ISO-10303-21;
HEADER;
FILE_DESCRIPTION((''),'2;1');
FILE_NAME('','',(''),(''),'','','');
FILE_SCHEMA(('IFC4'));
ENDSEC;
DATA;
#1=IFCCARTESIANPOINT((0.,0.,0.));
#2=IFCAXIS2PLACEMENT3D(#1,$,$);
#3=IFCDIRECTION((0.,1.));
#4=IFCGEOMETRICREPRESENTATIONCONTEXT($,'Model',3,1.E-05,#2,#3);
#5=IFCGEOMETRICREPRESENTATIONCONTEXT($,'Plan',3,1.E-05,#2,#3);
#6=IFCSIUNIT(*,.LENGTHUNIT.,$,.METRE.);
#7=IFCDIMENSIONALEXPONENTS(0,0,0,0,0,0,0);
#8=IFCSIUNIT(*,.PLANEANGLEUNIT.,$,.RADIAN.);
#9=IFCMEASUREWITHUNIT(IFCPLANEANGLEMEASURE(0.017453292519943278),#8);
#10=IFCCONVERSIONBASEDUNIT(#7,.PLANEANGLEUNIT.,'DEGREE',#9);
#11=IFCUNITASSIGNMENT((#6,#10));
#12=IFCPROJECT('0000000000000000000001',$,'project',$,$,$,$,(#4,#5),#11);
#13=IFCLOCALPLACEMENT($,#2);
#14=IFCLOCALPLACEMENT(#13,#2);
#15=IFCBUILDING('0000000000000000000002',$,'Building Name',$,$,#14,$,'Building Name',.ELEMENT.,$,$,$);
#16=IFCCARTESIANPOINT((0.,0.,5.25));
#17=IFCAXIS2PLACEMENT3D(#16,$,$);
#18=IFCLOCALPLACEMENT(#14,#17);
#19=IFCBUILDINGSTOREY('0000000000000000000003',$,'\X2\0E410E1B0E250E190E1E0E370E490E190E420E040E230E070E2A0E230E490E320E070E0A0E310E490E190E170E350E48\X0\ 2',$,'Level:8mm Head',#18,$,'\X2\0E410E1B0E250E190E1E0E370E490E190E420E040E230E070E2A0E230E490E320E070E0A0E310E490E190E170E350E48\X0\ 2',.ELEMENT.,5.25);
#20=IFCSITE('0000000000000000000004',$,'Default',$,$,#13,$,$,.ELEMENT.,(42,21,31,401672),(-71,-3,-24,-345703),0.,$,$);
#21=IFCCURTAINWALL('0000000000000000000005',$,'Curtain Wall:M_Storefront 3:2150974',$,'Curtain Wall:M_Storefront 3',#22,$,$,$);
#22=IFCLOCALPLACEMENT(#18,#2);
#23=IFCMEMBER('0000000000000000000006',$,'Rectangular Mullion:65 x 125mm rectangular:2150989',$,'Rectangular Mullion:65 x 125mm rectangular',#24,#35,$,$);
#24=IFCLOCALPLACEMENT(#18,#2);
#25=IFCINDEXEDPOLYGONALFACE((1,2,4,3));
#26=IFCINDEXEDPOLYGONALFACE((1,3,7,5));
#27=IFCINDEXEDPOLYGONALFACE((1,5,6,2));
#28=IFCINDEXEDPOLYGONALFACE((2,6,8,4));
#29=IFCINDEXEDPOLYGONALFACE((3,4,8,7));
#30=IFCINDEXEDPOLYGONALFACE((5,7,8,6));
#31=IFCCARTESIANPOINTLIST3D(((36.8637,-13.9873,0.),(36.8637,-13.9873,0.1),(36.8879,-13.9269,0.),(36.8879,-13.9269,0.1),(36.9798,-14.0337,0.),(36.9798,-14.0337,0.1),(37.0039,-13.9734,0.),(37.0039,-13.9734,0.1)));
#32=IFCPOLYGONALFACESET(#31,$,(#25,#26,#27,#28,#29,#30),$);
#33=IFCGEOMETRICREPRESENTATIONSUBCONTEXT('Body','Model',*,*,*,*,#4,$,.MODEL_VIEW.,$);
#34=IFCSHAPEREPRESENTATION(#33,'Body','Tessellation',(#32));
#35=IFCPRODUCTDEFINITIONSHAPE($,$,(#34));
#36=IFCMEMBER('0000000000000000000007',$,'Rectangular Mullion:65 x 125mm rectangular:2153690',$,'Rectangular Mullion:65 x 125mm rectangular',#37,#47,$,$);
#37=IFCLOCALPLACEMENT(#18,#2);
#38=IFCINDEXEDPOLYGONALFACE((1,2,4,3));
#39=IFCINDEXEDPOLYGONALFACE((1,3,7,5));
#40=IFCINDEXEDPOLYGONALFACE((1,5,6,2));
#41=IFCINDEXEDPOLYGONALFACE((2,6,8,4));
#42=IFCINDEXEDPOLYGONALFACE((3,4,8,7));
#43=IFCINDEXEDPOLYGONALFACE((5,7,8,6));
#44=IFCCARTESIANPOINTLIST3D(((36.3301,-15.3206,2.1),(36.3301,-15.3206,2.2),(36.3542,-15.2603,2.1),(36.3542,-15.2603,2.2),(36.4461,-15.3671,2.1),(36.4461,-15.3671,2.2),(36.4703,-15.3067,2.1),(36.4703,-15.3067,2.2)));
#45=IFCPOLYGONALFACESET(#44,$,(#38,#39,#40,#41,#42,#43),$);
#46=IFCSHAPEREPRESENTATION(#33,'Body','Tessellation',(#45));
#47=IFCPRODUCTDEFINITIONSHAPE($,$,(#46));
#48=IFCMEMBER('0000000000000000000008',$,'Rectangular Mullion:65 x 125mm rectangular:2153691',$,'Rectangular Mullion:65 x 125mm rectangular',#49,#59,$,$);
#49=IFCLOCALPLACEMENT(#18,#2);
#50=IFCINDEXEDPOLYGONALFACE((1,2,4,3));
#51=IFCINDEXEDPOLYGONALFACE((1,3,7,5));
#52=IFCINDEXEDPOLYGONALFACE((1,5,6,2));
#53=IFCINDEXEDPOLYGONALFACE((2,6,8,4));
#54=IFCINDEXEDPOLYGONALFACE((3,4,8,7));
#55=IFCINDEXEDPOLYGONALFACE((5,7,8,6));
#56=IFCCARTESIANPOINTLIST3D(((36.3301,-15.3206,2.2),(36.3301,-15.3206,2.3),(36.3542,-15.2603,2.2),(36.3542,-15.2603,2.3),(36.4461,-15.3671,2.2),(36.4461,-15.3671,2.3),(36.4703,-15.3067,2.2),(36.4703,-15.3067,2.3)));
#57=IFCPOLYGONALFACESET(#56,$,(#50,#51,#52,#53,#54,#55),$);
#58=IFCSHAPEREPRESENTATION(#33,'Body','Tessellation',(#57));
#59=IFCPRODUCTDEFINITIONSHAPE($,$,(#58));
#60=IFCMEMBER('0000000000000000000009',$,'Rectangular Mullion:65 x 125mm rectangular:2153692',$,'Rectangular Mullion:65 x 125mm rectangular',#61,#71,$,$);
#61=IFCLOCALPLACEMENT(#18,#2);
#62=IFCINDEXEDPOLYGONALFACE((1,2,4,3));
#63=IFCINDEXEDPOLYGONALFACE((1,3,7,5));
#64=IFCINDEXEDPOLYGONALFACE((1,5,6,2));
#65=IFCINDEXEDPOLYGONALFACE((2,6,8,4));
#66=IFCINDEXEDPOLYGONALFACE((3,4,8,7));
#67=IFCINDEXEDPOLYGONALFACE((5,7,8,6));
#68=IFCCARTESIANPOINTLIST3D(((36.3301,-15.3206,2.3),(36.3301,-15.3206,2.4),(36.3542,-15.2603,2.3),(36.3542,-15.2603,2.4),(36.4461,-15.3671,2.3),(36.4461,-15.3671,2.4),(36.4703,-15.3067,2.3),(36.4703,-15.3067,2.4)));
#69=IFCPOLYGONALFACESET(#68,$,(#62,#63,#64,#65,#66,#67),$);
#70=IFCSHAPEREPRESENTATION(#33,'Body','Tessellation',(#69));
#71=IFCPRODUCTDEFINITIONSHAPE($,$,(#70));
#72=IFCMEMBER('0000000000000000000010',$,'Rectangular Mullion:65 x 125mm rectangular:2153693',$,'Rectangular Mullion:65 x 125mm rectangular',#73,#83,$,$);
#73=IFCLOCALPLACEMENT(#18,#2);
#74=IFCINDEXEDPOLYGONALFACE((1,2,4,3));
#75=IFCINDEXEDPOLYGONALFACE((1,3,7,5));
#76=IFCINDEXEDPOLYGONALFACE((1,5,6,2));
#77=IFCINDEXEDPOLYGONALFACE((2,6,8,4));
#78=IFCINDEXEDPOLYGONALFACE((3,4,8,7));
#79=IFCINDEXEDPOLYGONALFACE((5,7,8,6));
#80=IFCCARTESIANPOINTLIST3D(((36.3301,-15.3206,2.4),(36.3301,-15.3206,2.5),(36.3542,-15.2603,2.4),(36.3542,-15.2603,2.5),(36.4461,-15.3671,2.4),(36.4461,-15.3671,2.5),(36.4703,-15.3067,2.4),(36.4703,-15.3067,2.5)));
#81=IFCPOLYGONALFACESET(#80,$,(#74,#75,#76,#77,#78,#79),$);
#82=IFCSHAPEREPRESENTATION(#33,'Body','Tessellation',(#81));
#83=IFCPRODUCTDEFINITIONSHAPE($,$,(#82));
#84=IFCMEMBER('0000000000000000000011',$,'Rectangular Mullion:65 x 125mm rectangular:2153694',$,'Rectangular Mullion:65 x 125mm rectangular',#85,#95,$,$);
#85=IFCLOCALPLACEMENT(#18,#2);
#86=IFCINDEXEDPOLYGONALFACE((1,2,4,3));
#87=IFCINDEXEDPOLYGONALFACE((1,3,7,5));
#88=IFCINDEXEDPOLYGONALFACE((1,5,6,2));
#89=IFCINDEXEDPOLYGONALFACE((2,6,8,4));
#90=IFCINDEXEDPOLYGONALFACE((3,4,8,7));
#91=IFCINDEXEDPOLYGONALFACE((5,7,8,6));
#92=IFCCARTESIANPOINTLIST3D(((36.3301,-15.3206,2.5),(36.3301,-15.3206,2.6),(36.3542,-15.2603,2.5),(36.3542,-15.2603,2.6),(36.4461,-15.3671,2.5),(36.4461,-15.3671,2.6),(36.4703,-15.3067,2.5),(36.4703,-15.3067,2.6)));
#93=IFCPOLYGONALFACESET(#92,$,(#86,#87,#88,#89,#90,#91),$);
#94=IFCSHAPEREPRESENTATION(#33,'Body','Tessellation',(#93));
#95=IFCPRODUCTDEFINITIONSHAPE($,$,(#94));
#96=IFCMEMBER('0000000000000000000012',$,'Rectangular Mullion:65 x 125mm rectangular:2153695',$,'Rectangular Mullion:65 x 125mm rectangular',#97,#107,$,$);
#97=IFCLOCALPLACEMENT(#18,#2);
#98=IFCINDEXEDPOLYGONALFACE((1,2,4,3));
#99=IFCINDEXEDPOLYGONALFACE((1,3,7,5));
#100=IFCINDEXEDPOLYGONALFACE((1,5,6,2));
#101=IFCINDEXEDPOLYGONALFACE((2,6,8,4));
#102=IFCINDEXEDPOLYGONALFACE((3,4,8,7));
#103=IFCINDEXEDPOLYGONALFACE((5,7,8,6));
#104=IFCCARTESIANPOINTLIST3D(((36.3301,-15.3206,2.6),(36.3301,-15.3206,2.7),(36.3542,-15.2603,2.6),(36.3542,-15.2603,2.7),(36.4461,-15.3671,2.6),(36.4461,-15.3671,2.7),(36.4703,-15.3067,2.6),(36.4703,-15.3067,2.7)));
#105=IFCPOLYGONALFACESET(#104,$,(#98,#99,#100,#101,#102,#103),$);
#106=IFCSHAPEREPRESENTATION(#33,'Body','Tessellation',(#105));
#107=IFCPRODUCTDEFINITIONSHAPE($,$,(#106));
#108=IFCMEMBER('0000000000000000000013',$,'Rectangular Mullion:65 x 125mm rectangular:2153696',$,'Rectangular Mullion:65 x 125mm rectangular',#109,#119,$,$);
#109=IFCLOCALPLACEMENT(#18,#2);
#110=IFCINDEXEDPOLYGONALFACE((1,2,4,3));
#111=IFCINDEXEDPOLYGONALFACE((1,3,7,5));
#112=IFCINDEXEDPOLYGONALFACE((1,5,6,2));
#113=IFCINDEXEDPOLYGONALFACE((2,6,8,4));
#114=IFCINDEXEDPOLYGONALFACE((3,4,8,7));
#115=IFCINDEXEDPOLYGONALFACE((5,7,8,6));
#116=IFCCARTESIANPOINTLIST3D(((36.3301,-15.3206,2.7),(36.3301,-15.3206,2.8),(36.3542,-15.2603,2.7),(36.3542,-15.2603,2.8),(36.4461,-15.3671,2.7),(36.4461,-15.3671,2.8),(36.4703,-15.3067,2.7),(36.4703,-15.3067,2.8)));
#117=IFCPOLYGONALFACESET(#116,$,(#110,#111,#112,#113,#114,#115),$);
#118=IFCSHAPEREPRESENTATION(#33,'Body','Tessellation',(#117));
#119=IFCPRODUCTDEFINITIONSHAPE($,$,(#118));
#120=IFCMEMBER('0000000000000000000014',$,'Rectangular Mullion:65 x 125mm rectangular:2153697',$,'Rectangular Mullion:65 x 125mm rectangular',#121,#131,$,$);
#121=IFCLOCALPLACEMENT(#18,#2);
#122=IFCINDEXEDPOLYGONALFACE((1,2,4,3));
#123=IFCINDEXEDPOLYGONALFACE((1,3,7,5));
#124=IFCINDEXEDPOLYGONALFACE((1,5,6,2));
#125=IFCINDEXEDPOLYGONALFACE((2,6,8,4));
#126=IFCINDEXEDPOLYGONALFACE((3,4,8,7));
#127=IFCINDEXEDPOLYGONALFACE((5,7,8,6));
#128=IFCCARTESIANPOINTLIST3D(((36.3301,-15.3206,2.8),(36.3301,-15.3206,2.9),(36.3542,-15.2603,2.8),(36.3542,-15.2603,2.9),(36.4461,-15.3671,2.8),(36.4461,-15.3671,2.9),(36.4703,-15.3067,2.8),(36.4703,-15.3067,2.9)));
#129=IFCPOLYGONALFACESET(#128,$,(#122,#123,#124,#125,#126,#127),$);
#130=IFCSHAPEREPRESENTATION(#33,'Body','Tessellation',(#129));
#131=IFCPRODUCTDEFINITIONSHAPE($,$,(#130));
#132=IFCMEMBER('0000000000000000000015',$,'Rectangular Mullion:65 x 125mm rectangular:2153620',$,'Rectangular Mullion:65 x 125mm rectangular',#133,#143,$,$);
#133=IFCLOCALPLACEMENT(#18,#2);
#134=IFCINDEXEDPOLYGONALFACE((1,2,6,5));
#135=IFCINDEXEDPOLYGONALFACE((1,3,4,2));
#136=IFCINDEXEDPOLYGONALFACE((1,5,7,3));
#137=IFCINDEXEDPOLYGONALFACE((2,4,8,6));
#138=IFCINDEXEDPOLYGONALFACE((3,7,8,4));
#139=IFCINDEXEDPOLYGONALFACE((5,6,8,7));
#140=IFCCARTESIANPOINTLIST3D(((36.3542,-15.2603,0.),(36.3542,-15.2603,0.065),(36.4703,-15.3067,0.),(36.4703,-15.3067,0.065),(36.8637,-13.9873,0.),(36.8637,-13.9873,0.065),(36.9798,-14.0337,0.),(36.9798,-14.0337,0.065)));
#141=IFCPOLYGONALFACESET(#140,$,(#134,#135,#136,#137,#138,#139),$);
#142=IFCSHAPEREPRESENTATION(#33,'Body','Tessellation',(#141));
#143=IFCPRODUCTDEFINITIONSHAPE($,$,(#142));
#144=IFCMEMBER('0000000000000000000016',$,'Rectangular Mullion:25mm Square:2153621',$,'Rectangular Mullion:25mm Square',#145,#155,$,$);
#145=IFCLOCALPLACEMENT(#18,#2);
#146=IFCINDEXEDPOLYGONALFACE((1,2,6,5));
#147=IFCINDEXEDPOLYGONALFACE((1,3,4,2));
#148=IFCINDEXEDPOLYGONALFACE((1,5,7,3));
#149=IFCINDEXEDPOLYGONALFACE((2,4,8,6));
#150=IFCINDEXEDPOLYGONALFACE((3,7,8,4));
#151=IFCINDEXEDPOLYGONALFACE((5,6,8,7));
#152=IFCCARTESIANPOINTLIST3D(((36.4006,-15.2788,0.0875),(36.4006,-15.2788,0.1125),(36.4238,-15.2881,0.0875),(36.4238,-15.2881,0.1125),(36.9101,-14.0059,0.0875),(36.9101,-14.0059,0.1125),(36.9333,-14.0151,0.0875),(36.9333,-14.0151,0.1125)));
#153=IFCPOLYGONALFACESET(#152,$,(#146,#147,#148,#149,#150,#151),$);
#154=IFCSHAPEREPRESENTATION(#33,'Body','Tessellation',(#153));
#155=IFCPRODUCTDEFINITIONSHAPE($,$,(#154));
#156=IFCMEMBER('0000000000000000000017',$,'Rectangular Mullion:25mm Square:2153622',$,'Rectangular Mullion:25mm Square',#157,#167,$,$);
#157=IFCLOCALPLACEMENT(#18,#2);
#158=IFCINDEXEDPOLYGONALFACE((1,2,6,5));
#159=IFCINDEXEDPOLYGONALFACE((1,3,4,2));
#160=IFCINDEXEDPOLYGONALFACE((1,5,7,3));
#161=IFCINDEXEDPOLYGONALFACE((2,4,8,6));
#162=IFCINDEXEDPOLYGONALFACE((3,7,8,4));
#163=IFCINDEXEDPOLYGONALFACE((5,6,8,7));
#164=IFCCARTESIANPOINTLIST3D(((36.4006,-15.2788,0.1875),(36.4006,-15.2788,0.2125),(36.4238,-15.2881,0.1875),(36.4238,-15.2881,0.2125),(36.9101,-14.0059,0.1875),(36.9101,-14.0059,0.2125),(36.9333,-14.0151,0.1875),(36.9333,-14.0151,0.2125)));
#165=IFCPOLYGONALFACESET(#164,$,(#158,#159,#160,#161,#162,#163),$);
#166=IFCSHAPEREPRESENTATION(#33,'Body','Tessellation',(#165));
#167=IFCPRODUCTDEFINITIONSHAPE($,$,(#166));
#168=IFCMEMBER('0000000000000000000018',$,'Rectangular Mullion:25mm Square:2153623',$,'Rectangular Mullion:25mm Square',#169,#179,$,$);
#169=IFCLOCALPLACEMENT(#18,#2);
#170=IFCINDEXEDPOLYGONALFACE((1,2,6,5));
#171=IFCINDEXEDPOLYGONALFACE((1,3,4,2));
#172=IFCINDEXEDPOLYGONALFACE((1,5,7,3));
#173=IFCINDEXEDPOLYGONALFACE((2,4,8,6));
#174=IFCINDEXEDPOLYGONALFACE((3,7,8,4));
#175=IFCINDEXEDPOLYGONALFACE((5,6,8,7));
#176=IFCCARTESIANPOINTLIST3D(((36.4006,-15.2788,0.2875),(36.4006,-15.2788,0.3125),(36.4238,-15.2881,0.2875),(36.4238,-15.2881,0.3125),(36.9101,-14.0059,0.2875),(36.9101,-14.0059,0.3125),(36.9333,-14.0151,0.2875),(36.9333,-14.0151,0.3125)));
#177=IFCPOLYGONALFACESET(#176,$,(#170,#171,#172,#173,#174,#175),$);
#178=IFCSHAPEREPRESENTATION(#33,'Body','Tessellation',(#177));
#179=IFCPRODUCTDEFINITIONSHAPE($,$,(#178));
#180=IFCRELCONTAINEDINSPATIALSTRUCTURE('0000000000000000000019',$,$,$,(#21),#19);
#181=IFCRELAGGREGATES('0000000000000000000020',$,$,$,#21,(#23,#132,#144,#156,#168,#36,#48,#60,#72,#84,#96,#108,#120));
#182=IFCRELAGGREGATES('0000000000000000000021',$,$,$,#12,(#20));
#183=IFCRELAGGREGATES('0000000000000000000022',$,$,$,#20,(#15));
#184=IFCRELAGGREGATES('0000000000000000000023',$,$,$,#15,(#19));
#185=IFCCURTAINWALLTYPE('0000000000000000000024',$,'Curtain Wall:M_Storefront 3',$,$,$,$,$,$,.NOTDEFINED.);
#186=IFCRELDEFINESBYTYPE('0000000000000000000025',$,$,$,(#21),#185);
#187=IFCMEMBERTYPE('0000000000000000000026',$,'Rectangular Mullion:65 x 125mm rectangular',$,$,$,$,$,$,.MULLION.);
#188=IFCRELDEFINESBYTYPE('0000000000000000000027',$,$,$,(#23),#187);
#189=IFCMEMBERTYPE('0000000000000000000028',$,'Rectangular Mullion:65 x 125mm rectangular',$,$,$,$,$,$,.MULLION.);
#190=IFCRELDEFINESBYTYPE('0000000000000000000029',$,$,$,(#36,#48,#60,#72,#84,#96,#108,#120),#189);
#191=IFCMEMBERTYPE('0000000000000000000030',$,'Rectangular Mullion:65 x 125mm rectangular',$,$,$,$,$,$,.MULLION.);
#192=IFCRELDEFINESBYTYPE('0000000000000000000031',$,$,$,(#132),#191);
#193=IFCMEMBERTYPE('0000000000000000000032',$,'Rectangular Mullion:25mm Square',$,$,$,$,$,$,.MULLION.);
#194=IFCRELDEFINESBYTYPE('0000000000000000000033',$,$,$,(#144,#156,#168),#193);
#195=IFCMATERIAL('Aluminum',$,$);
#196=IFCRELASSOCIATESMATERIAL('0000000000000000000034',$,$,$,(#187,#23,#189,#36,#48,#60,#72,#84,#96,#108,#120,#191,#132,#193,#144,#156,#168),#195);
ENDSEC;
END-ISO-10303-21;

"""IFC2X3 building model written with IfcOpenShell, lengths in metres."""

from ifc_helpers import new_model, entity, si_unit, converted_unit, direction, frame, frame_2d, origin, origin_2d_with_axis, place, context, subcontext, project, spatial, rectangle, extrude, source, transform, mapped, material, type_object, type_shapes, element, aggregate, save


model = new_model("IFC2X3")

# Units and contexts
model_context = context("Model", 3, precision=1e-05, world=origin(), true_north=direction((0.0, 1.0)))
plan_context = context("Plan", 3, precision=1e-05, world=origin(), true_north=direction((0.0, 1.0)))
body_context = subcontext(model_context, "Body", "Model", "MODEL_VIEW")
ifc_project = project(units=[si_unit("LENGTHUNIT", "METRE"), converted_unit("PLANEANGLEUNIT", "DEGREE", entity("IfcPlaneAngleMeasure", 0.017453292519943278), si_unit("PLANEANGLEUNIT", "RADIAN"), dimensions=[0, 0, 0, 0, 0, 0, 0])], contexts=[model_context, plan_context])

# Site, building, storey
site_placement = place(None, origin())
site = spatial("IfcSite", under=ifc_project, at=site_placement, Name="Default", CompositionType="ELEMENT", RefLatitude=(42, 21, 31, 401672), RefLongitude=(-71, -3, -24, -345703), RefElevation=0.0)
building_placement = place(site_placement, origin())
building = spatial("IfcBuilding", under=site, at=building_placement, Name="Building Name", LongName="Building Name", CompositionType="ELEMENT")
storey_placement = place(building_placement, frame((0.0, 0.0, 5.25)))
storey = spatial("IfcBuildingStorey", under=building, at=storey_placement, Name="แปลนพื้นโครงสร้างชั้นที่ 2", ObjectType="Level:8mm Head", LongName="แปลนพื้นโครงสร้างชั้นที่ 2", CompositionType="ELEMENT", Elevation=5.25)

# Curtain wall, members
curtain_wall_type = type_object("IfcCurtainWallType", Name="Curtain Wall:M_Storefront 3", PredefinedType="NOTDEFINED")
curtain_wall_placement = place(storey_placement, frame((0.0, 0.0, -5.25)))
curtain_wall = element("IfcCurtainWall", 1, at=curtain_wall_placement, inside=storey, type_object=curtain_wall_type, Name="Curtain Wall:M_Storefront 3:2150974", ObjectType="Curtain Wall:M_Storefront 3")
ifc_material_1 = material(Name="Aluminum")
member_type_1 = type_object("IfcMemberType", Name="Rectangular Mullion:65 x 125mm rectangular", PredefinedType="MULLION", material=ifc_material_1)
shared_shape_1 = source(origin(), body_context, "Body", "SweptSolid", [
    extrude(rectangle(XDim=0.065, YDim=0.125, at=origin_2d_with_axis()), frame((-0.0325, 0.0, -0.1), z_axis=(0.0, 0.0, 1.0), x_axis=(-1.0, 0.0, 0.0)), (0.0, 0.0, 1.0), 0.1),
])
type_shapes(member_type_1, [shared_shape_1])
member_1_placement = place(curtain_wall_placement, frame((36.9459, -13.9502, 5.25), z_axis=(0.0, 0.0, -1.0), x_axis=(0.371573, 0.928404, 0.0)))
member_1 = element("IfcMember", 2, at=member_1_placement, type_object=member_type_1, material=ifc_material_1, Name="Rectangular Mullion:65 x 125mm rectangular:2150989", ObjectType="Rectangular Mullion:65 x 125mm rectangular", context=body_context, shape_type="MappedRepresentation", body=[
    mapped(shared_shape_1, transform((0.0, 0.0, 0.0), scale=1.0)),
])
member_type_2 = type_object("IfcMemberType", Name="Rectangular Mullion:65 x 125mm rectangular", PredefinedType="MULLION", material=ifc_material_1)
shared_shape_2 = source(origin(), body_context, "Body", "SweptSolid", [
    extrude(rectangle(XDim=0.065, YDim=0.125, at=frame_2d((0.0, 0.0), x_axis=(1.0, 0.0))), frame((0.0, 0.0, -0.1), z_axis=(0.0, 0.0, 1.0), x_axis=(-1.0, 0.0, 0.0)), (0.0, 0.0, 1.0), 0.1),
])
type_shapes(member_type_2, [shared_shape_2])
member_2_placement = place(curtain_wall_placement, frame((36.4002, -15.3137, 7.35), z_axis=(0.0, 0.0, -1.0), x_axis=(0.371573, 0.928404, 0.0)))
member_2 = element("IfcMember", 3, at=member_2_placement, type_object=member_type_2, material=ifc_material_1, Name="Rectangular Mullion:65 x 125mm rectangular:2153690", ObjectType="Rectangular Mullion:65 x 125mm rectangular", context=body_context, shape_type="MappedRepresentation", body=[
    mapped(shared_shape_2, transform((0.0, 0.0, 0.0), scale=1.0)),
])
member_3_placement = place(curtain_wall_placement, frame((36.4002, -15.3137, 7.45), z_axis=(0.0, 0.0, -1.0), x_axis=(0.371573, 0.928404, 0.0)))
member_3 = element("IfcMember", 4, at=member_3_placement, type_object=member_type_2, material=ifc_material_1, Name="Rectangular Mullion:65 x 125mm rectangular:2153691", ObjectType="Rectangular Mullion:65 x 125mm rectangular", context=body_context, shape_type="MappedRepresentation", body=[
    mapped(shared_shape_2, transform((0.0, 0.0, 0.0), scale=1.0)),
])
member_4_placement = place(curtain_wall_placement, frame((36.4002, -15.3137, 7.55), z_axis=(0.0, 0.0, -1.0), x_axis=(0.371573, 0.928404, 0.0)))
member_4 = element("IfcMember", 5, at=member_4_placement, type_object=member_type_2, material=ifc_material_1, Name="Rectangular Mullion:65 x 125mm rectangular:2153692", ObjectType="Rectangular Mullion:65 x 125mm rectangular", context=body_context, shape_type="MappedRepresentation", body=[
    mapped(shared_shape_2, transform((0.0, 0.0, 0.0), scale=1.0)),
])
member_5_placement = place(curtain_wall_placement, frame((36.4002, -15.3137, 7.65), z_axis=(0.0, 0.0, -1.0), x_axis=(0.371573, 0.928404, 0.0)))
member_5 = element("IfcMember", 6, at=member_5_placement, type_object=member_type_2, material=ifc_material_1, Name="Rectangular Mullion:65 x 125mm rectangular:2153693", ObjectType="Rectangular Mullion:65 x 125mm rectangular", context=body_context, shape_type="MappedRepresentation", body=[
    mapped(shared_shape_2, transform((0.0, 0.0, 0.0), scale=1.0)),
])
member_6_placement = place(curtain_wall_placement, frame((36.4002, -15.3137, 7.75), z_axis=(0.0, 0.0, -1.0), x_axis=(0.371573, 0.928404, 0.0)))
member_6 = element("IfcMember", 7, at=member_6_placement, type_object=member_type_2, material=ifc_material_1, Name="Rectangular Mullion:65 x 125mm rectangular:2153694", ObjectType="Rectangular Mullion:65 x 125mm rectangular", context=body_context, shape_type="MappedRepresentation", body=[
    mapped(shared_shape_2, transform((0.0, 0.0, 0.0), scale=1.0)),
])
member_7_placement = place(curtain_wall_placement, frame((36.4002, -15.3137, 7.85), z_axis=(0.0, 0.0, -1.0), x_axis=(0.371573, 0.928404, 0.0)))
member_7 = element("IfcMember", 8, at=member_7_placement, type_object=member_type_2, material=ifc_material_1, Name="Rectangular Mullion:65 x 125mm rectangular:2153695", ObjectType="Rectangular Mullion:65 x 125mm rectangular", context=body_context, shape_type="MappedRepresentation", body=[
    mapped(shared_shape_2, transform((0.0, 0.0, 0.0), scale=1.0)),
])
member_8_placement = place(curtain_wall_placement, frame((36.4002, -15.3137, 7.95), z_axis=(0.0, 0.0, -1.0), x_axis=(0.371573, 0.928404, 0.0)))
member_8 = element("IfcMember", 9, at=member_8_placement, type_object=member_type_2, material=ifc_material_1, Name="Rectangular Mullion:65 x 125mm rectangular:2153696", ObjectType="Rectangular Mullion:65 x 125mm rectangular", context=body_context, shape_type="MappedRepresentation", body=[
    mapped(shared_shape_2, transform((0.0, 0.0, 0.0), scale=1.0)),
])
member_9_placement = place(curtain_wall_placement, frame((36.4002, -15.3137, 8.05), z_axis=(0.0, 0.0, -1.0), x_axis=(0.371573, 0.928404, 0.0)))
member_9 = element("IfcMember", 10, at=member_9_placement, type_object=member_type_2, material=ifc_material_1, Name="Rectangular Mullion:65 x 125mm rectangular:2153697", ObjectType="Rectangular Mullion:65 x 125mm rectangular", context=body_context, shape_type="MappedRepresentation", body=[
    mapped(shared_shape_2, transform((0.0, 0.0, 0.0), scale=1.0)),
])
member_type_3 = type_object("IfcMemberType", Name="Rectangular Mullion:65 x 125mm rectangular", PredefinedType="MULLION", material=ifc_material_1)
shared_shape_3 = source(origin(), body_context, "Body", "SweptSolid", [
    extrude(rectangle(XDim=0.065, YDim=0.125, at=origin_2d_with_axis()), frame((-0.0325, 0.0, -1.3712), z_axis=(0.0, 0.0, 1.0), x_axis=(-1.0, 0.0, 0.0)), (0.0, 0.0, 1.0), 1.3712),
])
type_shapes(member_type_3, [shared_shape_3])
member_10_placement = place(curtain_wall_placement, frame((36.4122, -15.2835, 5.25), z_axis=(-0.371573, -0.928404, 0.0), x_axis=(0.0, 0.0, -1.0)))
member_10 = element("IfcMember", 11, at=member_10_placement, type_object=member_type_3, material=ifc_material_1, Name="Rectangular Mullion:65 x 125mm rectangular:2153620", ObjectType="Rectangular Mullion:65 x 125mm rectangular", context=body_context, shape_type="MappedRepresentation", body=[
    mapped(shared_shape_3, transform((0.0, 0.0, 0.0), scale=1.0)),
])
member_type_4 = type_object("IfcMemberType", Name="Rectangular Mullion:25mm Square", PredefinedType="MULLION", material=ifc_material_1)
shared_shape_4 = source(origin(), body_context, "Body", "SweptSolid", [
    extrude(rectangle(XDim=0.025, YDim=0.025, at=frame_2d((0.0, 0.0), x_axis=(1.0, 0.0))), frame((0.0, 0.0, -1.3712), z_axis=(0.0, 0.0, 1.0), x_axis=(-1.0, 0.0, 0.0)), (0.0, 0.0, 1.0), 1.3712),
])
type_shapes(member_type_4, [shared_shape_4])
member_11_placement = place(curtain_wall_placement, frame((36.9217, -14.0105, 5.35), z_axis=(0.371573, 0.928404, 0.0), x_axis=(0.0, 0.0, 1.0)))
member_11 = element("IfcMember", 12, at=member_11_placement, type_object=member_type_4, material=ifc_material_1, Name="Rectangular Mullion:25mm Square:2153621", ObjectType="Rectangular Mullion:25mm Square", context=body_context, shape_type="MappedRepresentation", body=[
    mapped(shared_shape_4, transform((0.0, 0.0, 0.0), scale=1.0)),
])
member_12_placement = place(curtain_wall_placement, frame((36.9217, -14.0105, 5.45), z_axis=(0.371573, 0.928404, 0.0), x_axis=(0.0, 0.0, 1.0)))
member_12 = element("IfcMember", 13, at=member_12_placement, type_object=member_type_4, material=ifc_material_1, Name="Rectangular Mullion:25mm Square:2153622", ObjectType="Rectangular Mullion:25mm Square", context=body_context, shape_type="MappedRepresentation", body=[
    mapped(shared_shape_4, transform((0.0, 0.0, 0.0), scale=1.0)),
])
member_13_placement = place(curtain_wall_placement, frame((36.9217, -14.0105, 5.55), z_axis=(0.371573, 0.928404, 0.0), x_axis=(0.0, 0.0, 1.0)))
member_13 = element("IfcMember", 14, at=member_13_placement, type_object=member_type_4, material=ifc_material_1, Name="Rectangular Mullion:25mm Square:2153623", ObjectType="Rectangular Mullion:25mm Square", context=body_context, shape_type="MappedRepresentation", body=[
    mapped(shared_shape_4, transform((0.0, 0.0, 0.0), scale=1.0)),
])
aggregate(curtain_wall, [member_1, member_10, member_11, member_12, member_13, member_2, member_3, member_4, member_5, member_6, member_7, member_8, member_9])

save(model, "model.ifc")
